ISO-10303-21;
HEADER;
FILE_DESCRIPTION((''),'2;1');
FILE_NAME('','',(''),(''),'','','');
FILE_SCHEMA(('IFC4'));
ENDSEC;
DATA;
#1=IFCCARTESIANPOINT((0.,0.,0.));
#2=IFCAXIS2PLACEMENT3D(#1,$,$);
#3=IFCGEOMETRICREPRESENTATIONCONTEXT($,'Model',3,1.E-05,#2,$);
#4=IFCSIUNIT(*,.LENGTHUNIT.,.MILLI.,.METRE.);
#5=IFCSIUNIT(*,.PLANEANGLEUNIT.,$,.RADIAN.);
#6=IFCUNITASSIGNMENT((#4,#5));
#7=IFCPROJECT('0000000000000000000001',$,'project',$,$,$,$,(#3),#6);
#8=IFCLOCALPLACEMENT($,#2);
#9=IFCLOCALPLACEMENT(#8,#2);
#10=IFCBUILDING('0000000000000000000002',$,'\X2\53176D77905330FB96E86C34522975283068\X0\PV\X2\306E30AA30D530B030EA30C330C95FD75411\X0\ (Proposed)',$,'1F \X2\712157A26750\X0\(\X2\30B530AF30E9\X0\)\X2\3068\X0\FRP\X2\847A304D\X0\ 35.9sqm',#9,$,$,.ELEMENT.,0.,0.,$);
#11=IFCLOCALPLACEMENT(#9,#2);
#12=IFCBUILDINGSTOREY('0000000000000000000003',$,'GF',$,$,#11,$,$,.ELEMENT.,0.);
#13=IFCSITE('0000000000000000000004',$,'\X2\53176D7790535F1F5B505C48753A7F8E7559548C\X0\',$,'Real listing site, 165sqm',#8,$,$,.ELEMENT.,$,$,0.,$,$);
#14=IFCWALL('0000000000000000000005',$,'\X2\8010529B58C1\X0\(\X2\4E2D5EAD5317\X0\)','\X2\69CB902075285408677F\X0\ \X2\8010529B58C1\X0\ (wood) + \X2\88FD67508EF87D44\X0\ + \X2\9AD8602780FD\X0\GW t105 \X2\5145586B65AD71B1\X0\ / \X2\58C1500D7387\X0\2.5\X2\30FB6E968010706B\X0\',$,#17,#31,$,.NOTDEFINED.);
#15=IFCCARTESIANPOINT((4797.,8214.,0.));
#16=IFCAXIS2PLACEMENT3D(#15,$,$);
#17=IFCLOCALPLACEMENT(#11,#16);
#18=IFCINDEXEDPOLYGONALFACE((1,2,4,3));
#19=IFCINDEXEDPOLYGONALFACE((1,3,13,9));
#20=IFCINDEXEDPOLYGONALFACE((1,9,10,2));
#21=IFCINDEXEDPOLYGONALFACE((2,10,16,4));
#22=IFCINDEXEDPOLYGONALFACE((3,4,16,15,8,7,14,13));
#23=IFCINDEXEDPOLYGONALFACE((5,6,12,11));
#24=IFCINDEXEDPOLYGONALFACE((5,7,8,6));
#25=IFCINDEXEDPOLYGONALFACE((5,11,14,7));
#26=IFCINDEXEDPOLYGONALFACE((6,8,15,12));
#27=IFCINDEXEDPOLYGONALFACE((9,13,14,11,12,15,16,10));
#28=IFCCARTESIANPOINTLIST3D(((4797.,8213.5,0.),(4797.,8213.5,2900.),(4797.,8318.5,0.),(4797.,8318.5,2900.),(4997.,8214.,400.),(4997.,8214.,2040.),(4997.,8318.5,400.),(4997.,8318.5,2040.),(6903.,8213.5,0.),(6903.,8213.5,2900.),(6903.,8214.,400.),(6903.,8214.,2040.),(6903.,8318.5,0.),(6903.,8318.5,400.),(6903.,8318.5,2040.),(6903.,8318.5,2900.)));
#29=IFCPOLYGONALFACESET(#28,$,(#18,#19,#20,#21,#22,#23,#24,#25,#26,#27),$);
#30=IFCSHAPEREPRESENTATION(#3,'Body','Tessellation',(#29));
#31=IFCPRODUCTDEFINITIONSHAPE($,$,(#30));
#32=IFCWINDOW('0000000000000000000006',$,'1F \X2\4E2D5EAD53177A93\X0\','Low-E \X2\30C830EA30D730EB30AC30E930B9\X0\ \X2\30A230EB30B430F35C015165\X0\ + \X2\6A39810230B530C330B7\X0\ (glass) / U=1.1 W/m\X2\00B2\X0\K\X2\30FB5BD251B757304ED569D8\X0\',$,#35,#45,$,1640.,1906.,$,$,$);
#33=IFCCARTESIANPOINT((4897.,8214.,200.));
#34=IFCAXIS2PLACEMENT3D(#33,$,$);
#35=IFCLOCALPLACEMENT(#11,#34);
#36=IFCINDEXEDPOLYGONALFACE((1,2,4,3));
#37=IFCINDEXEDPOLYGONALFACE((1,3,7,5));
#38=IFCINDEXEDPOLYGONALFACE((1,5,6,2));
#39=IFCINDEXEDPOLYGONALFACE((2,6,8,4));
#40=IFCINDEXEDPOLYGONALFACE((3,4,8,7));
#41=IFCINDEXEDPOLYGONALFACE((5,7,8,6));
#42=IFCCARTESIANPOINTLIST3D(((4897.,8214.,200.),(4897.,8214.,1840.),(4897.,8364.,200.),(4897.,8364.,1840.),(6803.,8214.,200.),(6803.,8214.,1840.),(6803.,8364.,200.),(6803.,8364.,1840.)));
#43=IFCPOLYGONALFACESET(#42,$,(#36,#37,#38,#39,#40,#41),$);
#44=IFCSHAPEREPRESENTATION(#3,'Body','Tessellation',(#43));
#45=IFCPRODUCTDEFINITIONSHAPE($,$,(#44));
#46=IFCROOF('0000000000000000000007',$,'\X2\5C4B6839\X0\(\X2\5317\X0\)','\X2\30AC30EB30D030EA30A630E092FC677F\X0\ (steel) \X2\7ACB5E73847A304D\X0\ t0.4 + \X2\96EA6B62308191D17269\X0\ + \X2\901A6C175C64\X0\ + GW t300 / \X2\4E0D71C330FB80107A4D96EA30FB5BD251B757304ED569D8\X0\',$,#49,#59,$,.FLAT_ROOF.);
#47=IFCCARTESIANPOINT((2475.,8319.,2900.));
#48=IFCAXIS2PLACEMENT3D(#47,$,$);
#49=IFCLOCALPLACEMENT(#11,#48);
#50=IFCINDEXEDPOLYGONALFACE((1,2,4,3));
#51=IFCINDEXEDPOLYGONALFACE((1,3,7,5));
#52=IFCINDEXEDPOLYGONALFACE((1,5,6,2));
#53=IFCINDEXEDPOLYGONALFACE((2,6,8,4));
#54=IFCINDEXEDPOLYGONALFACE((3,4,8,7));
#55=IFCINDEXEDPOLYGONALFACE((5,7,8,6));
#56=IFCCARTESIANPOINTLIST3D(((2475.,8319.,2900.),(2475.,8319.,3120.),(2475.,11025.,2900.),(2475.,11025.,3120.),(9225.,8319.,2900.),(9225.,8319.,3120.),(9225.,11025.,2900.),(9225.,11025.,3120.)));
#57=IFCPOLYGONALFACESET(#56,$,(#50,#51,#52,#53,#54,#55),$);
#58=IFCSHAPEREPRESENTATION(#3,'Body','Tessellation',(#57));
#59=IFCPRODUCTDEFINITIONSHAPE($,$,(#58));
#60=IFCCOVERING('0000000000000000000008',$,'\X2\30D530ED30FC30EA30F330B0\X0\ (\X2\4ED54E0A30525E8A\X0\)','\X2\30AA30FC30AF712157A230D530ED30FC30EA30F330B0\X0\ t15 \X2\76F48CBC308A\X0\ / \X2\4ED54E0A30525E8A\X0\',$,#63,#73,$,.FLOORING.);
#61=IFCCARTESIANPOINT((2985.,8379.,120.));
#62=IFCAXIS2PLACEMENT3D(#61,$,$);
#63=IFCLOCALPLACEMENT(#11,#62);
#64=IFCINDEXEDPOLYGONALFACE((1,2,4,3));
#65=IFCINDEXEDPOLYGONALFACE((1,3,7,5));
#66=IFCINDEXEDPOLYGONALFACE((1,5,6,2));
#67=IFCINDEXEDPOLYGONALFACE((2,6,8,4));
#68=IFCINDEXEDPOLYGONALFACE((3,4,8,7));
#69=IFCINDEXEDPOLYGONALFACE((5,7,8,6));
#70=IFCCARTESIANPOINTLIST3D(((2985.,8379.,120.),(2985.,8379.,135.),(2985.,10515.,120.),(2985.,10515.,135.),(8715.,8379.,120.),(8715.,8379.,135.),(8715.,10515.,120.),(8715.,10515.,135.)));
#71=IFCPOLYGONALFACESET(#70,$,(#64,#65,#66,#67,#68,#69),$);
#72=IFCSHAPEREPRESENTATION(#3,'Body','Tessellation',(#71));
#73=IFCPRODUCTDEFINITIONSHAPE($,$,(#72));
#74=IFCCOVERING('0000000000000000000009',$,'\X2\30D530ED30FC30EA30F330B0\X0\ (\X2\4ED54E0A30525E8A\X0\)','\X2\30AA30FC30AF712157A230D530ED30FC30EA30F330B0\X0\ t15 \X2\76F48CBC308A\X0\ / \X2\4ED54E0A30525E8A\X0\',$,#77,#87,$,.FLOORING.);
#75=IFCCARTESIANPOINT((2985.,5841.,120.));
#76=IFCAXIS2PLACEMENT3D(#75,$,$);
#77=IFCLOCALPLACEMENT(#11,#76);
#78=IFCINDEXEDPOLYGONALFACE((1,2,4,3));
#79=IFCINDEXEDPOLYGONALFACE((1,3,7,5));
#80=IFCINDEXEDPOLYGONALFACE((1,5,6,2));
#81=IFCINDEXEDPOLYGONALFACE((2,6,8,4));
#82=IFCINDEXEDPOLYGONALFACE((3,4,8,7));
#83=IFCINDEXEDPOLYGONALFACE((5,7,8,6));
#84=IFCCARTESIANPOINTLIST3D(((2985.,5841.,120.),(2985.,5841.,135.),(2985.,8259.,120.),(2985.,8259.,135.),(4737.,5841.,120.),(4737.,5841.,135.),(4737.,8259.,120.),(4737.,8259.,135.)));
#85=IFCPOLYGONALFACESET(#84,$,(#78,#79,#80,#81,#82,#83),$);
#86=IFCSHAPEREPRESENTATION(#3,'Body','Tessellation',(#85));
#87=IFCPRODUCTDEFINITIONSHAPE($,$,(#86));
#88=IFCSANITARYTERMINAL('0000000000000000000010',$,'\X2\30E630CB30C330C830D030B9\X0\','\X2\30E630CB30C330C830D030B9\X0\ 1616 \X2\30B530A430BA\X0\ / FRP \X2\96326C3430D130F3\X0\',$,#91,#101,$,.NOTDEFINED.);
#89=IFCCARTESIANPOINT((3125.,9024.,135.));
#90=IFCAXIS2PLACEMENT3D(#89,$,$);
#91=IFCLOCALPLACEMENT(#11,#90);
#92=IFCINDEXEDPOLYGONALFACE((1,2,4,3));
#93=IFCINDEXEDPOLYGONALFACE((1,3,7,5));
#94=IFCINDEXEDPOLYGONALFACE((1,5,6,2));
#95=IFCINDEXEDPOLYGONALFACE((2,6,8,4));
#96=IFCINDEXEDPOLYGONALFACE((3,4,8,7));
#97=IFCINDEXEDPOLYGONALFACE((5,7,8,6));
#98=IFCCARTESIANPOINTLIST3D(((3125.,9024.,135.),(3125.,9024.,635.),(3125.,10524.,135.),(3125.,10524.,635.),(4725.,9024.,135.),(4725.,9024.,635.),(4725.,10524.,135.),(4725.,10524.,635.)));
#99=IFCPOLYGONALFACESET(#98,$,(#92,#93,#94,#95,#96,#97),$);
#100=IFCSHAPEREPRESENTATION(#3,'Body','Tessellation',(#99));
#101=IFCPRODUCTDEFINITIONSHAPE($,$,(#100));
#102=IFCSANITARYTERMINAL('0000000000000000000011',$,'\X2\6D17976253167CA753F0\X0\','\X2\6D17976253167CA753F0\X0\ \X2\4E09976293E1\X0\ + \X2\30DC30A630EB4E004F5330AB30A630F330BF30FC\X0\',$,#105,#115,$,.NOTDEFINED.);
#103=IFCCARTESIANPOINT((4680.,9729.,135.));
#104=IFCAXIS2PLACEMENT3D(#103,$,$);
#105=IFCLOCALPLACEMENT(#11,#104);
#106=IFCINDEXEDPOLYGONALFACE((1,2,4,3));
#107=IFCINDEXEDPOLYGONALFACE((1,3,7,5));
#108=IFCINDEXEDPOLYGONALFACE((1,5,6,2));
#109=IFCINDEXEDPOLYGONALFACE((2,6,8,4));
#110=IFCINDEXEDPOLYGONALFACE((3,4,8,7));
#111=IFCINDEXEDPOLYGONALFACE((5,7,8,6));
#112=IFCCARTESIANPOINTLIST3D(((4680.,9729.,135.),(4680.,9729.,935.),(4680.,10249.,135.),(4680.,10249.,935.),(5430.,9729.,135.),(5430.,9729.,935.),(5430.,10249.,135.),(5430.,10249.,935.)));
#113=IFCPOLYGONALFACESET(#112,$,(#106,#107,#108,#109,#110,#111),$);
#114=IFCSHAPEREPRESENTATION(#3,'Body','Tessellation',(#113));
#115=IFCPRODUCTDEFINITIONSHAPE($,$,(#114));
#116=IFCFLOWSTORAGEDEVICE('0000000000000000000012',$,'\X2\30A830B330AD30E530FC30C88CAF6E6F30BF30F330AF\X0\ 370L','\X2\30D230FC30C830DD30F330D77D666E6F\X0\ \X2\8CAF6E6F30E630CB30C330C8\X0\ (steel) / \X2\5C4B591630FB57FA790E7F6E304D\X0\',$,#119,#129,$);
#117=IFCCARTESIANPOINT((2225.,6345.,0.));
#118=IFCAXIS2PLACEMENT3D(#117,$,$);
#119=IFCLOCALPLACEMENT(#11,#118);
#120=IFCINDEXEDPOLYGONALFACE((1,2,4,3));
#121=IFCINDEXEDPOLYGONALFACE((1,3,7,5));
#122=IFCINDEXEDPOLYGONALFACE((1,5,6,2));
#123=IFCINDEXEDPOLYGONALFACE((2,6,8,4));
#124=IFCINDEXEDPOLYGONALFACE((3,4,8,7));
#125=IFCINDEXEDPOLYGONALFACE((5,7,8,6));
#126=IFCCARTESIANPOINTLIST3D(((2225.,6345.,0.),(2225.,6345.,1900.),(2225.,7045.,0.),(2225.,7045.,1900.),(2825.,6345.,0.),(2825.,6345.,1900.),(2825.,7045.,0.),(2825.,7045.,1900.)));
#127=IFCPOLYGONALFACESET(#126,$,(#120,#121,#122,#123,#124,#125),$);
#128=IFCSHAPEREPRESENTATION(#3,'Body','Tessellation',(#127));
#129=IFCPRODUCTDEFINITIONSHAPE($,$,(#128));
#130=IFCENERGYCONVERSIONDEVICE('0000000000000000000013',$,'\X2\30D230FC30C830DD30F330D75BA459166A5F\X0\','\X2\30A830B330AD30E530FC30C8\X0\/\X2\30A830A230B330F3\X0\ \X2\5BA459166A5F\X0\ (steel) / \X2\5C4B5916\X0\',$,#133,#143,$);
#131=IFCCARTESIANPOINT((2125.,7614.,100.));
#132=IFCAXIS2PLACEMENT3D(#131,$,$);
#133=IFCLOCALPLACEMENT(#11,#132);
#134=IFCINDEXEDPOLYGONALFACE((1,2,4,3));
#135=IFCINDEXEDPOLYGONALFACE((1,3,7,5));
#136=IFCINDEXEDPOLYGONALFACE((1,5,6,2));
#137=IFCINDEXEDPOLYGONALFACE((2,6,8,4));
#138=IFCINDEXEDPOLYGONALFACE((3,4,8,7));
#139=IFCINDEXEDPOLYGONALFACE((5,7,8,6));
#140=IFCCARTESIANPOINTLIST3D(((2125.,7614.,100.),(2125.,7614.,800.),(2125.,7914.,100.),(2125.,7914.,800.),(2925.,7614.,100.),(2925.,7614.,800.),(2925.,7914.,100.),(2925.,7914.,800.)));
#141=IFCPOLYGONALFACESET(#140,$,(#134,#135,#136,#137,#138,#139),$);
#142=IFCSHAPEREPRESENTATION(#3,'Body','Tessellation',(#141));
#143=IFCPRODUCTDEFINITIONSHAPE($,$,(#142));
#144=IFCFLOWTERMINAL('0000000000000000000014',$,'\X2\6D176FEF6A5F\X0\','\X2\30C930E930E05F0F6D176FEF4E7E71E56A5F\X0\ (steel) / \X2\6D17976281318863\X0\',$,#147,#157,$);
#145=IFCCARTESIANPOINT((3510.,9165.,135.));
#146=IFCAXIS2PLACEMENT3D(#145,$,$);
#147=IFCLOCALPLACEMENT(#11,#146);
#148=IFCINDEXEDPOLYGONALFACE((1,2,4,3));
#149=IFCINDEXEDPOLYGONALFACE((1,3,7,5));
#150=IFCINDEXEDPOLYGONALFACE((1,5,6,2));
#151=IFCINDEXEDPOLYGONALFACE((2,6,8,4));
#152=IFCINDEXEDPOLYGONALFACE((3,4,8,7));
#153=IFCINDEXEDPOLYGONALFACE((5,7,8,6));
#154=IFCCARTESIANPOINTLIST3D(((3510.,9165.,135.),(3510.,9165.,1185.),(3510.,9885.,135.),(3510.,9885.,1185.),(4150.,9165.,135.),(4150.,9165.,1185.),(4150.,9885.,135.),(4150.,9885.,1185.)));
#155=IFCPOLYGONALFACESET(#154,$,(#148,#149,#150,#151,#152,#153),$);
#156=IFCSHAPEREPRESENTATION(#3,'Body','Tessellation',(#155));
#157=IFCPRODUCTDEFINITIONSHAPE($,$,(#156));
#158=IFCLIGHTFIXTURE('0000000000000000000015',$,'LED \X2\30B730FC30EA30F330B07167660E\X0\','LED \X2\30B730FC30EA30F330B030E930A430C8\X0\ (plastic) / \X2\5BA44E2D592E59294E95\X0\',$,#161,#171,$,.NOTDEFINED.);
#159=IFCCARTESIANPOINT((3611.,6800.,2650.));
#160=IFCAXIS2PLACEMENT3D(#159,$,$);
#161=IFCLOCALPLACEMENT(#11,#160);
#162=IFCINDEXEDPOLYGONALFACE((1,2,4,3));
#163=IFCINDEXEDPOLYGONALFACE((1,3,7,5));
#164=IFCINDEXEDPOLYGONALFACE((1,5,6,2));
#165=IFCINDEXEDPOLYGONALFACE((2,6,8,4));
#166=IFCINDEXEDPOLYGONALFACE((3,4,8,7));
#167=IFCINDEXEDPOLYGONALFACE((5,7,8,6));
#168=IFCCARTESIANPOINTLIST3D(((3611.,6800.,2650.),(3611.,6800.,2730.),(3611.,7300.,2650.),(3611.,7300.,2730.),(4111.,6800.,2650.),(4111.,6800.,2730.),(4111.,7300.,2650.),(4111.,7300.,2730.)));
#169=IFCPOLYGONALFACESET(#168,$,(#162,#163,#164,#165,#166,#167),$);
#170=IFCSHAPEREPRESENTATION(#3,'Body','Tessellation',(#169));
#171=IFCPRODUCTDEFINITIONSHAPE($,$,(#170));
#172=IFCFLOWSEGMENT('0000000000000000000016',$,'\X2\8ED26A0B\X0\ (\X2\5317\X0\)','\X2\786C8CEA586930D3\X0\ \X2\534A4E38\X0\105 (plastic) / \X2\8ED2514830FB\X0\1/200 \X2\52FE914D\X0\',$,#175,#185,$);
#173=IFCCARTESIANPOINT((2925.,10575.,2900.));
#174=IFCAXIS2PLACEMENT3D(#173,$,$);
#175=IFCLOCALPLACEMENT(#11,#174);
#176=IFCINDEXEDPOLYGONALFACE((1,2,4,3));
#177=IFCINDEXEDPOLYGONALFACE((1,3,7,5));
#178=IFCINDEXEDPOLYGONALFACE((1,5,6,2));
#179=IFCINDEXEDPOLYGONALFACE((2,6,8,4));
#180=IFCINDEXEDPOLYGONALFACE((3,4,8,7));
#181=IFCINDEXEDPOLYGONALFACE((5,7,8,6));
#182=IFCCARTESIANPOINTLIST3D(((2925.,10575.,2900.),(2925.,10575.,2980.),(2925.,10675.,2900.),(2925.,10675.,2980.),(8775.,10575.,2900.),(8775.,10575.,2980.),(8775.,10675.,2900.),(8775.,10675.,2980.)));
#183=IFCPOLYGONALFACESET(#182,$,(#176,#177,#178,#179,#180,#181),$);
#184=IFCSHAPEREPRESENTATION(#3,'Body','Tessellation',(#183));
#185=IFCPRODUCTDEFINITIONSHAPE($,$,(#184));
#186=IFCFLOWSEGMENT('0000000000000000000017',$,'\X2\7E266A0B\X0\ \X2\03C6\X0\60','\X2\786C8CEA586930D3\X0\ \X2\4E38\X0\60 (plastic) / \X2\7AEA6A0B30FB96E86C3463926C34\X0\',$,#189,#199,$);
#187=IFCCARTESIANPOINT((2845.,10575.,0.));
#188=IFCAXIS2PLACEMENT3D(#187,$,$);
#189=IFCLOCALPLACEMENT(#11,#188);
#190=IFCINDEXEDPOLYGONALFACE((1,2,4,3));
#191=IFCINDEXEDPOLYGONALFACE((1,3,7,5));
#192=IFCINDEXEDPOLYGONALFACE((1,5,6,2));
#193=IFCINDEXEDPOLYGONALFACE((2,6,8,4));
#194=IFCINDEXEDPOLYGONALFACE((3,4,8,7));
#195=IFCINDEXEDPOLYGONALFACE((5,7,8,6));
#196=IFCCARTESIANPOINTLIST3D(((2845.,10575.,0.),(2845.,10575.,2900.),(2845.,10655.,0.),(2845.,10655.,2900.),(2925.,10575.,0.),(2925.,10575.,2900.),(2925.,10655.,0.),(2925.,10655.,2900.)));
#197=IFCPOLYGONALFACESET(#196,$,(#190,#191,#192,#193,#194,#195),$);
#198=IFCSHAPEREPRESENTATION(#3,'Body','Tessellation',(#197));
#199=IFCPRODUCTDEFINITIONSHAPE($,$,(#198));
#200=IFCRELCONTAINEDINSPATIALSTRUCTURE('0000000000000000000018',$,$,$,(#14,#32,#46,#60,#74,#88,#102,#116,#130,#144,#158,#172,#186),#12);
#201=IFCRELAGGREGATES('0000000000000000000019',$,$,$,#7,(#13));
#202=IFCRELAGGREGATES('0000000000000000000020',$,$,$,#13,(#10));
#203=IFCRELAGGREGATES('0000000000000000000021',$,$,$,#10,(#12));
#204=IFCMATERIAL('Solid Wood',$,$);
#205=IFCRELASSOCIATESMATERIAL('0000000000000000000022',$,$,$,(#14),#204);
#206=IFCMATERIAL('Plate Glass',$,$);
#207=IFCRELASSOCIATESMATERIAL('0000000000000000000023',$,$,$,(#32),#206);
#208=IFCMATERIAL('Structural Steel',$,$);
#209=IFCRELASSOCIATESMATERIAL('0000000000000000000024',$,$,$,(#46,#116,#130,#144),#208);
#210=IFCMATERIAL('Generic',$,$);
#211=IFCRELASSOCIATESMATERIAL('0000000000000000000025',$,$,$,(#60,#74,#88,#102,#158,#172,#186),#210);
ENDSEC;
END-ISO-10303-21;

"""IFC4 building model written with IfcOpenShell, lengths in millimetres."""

from ifc_helpers import new_model, si_unit, frame, frame_2d, origin, place, context, project, spatial, rectangle, extrude, material, element, fill, save


model = new_model("IFC4")

# Units and contexts
model_context = context("Model", 3, precision=1e-05, world=origin())
ifc_project = project(units=[si_unit("LENGTHUNIT", "METRE", prefix="MILLI"), si_unit("PLANEANGLEUNIT", "RADIAN")], contexts=[model_context])

# Site, building, storey
site_placement = place(None, origin())
site = spatial("IfcSite", under=ifc_project, at=site_placement, Name="北海道弟子屈町美留和", ObjectType="Real listing site, 165sqm", CompositionType="ELEMENT", RefElevation=0.0)
building_placement = place(site_placement, origin())
building = spatial("IfcBuilding", under=site, at=building_placement, Name="北海道・雨水利用とPVのオフグリッド志向 (Proposed)", ObjectType="1F 無垢材(サクラ)とFRP葺き 35.9sqm", CompositionType="ELEMENT", ElevationOfRefHeight=0.0, ElevationOfTerrain=0.0)
storey_placement = place(building_placement, origin())
storey = spatial("IfcBuildingStorey", under=building, at=storey_placement, Name="GF", CompositionType="ELEMENT", Elevation=0.0)

# Shared definitions
ifc_material_1 = material(Name="Solid Wood")

# Shared definitions
ifc_material_2 = material(Name="Plate Glass")

# Wall, opening, window
wall_1_placement = place(storey_placement, frame((4797.0, 8214.0, 0.0)))
wall_1 = element("IfcWall", 1, at=wall_1_placement, inside=storey, material=ifc_material_1, Name="耐力壁(中庭北)", Description="構造用合板 耐力壁 (wood) + 製材軸組 + 高性能GW t105 充填断熱 / 壁倍率2.5・準耐火", PredefinedType="NOTDEFINED", context=model_context, shape_type="SweptSolid", body=[
    extrude(rectangle(XDim=2106.0, YDim=105.0, at=frame_2d((1053.0, 52.0))), frame((4797.0, 8214.0, 0.0)), (0.0, 0.0, 1.0), 2900.0),
])
opening_1_placement = place(storey_placement, frame((4897.0, 8214.0, 200.0)))
opening_1 = element("IfcOpeningElement", 2, at=opening_1_placement, cuts=wall_1, PredefinedType="NOTDEFINED", context=model_context, shape_type="SweptSolid", body=[
    extrude(rectangle(XDim=1906.0, YDim=150.0, at=frame_2d((953.0, 75.0))), frame((4897.0, 8214.0, 200.0)), (0.0, 0.0, 1.0), 1640.0),
])
window_1_placement = place(storey_placement, frame((4897.0, 8214.0, 200.0)))
window_1 = element("IfcWindow", 3, at=window_1_placement, inside=storey, material=ifc_material_2, Name="1F 中庭北窓", Description="Low-E トリプルガラス アルゴン封入 + 樹脂サッシ (glass) / U=1.1 W/m²K・寒冷地仕様", OverallHeight=1640.0, OverallWidth=1906.0, context=model_context, shape_type="SweptSolid", body=[
    extrude(rectangle(XDim=1906.0, YDim=150.0, at=frame_2d((953.0, 75.0))), frame((4897.0, 8214.0, 200.0)), (0.0, 0.0, 1.0), 1640.0),
])
fill(opening_1, window_1)

# Roof
ifc_material_3 = material(Name="Structural Steel")
roof_placement = place(storey_placement, frame((2475.0, 8319.0, 2900.0)))
element("IfcRoof", 4, at=roof_placement, inside=storey, material=ifc_material_3, Name="屋根(北)", Description="ガルバリウム鋼板 (steel) 立平葺き t0.4 + 雪止め金物 + 通気層 + GW t300 / 不燃・耐積雪・寒冷地仕様", PredefinedType="FLAT_ROOF", context=model_context, shape_type="SweptSolid", body=[
    extrude(rectangle(XDim=6750.0, YDim=2706.0, at=frame_2d((3375.0, 1353.0))), frame((2475.0, 8319.0, 2900.0)), (0.0, 0.0, 1.0), 220.0),
])

# Coverings
ifc_material_4 = material(Name="Generic")
covering_1_placement = place(storey_placement, frame((2985.0, 8379.0, 120.0)))
element("IfcCovering", 5, at=covering_1_placement, inside=storey, material=ifc_material_4, Name="フローリング (仕上げ床)", Description="オーク無垢フローリング t15 直貼り / 仕上げ床", PredefinedType="FLOORING", context=model_context, shape_type="SweptSolid", body=[
    extrude(rectangle(XDim=5730.0, YDim=2136.0, at=frame_2d((2865.0, 1068.0))), frame((2985.0, 8379.0, 120.0)), (0.0, 0.0, 1.0), 15.0),
])
covering_2_placement = place(storey_placement, frame((2985.0, 5841.0, 120.0)))
element("IfcCovering", 6, at=covering_2_placement, inside=storey, material=ifc_material_4, Name="フローリング (仕上げ床)", Description="オーク無垢フローリング t15 直貼り / 仕上げ床", PredefinedType="FLOORING", context=model_context, shape_type="SweptSolid", body=[
    extrude(rectangle(XDim=1752.0, YDim=2418.0, at=frame_2d((876.0, 1209.0))), frame((2985.0, 5841.0, 120.0)), (0.0, 0.0, 1.0), 15.0),
])

# Sanitary terminals
sanitary_terminal_1_placement = place(storey_placement, frame((3125.0, 9024.0, 135.0)))
element("IfcSanitaryTerminal", 7, at=sanitary_terminal_1_placement, inside=storey, material=ifc_material_4, Name="ユニットバス", Description="ユニットバス 1616 サイズ / FRP 防水パン", PredefinedType="NOTDEFINED", context=model_context, shape_type="SweptSolid", body=[
    extrude(rectangle(XDim=1600.0, YDim=1500.0, at=frame_2d((800.0, 750.0))), frame((3125.0, 9024.0, 135.0)), (0.0, 0.0, 1.0), 500.0),
])
sanitary_terminal_2_placement = place(storey_placement, frame((4680.0, 9729.0, 135.0)))
element("IfcSanitaryTerminal", 8, at=sanitary_terminal_2_placement, inside=storey, material=ifc_material_4, Name="洗面化粧台", Description="洗面化粧台 三面鏡 + ボウル一体カウンター", PredefinedType="NOTDEFINED", context=model_context, shape_type="SweptSolid", body=[
    extrude(rectangle(XDim=750.0, YDim=520.0, at=frame_2d((375.0, 260.0))), frame((4680.0, 9729.0, 135.0)), (0.0, 0.0, 1.0), 800.0),
])

# Flow storage device
flow_storage_device_placement = place(storey_placement, frame((2225.0, 6345.0, 0.0)))
element("IfcFlowStorageDevice", 9, at=flow_storage_device_placement, inside=storey, material=ifc_material_3, Name="エコキュート貯湯タンク 370L", Description="ヒートポンプ給湯 貯湯ユニット (steel) / 屋外・基礎置き", context=model_context, shape_type="SweptSolid", body=[
    extrude(rectangle(XDim=600.0, YDim=700.0, at=frame_2d((300.0, 350.0))), frame((2225.0, 6345.0, 0.0)), (0.0, 0.0, 1.0), 1900.0),
])

# Energy conversion device
energy_conversion_device_placement = place(storey_placement, frame((2125.0, 7614.0, 100.0)))
element("IfcEnergyConversionDevice", 10, at=energy_conversion_device_placement, inside=storey, material=ifc_material_3, Name="ヒートポンプ室外機", Description="エコキュート/エアコン 室外機 (steel) / 屋外", context=model_context, shape_type="SweptSolid", body=[
    extrude(rectangle(XDim=800.0, YDim=300.0, at=frame_2d((400.0, 150.0))), frame((2125.0, 7614.0, 100.0)), (0.0, 0.0, 1.0), 700.0),
])

# Flow terminal
flow_terminal_placement = place(storey_placement, frame((3510.0, 9165.0, 135.0)))
element("IfcFlowTerminal", 11, at=flow_terminal_placement, inside=storey, material=ifc_material_3, Name="洗濯機", Description="ドラム式洗濯乾燥機 (steel) / 洗面脱衣", context=model_context, shape_type="SweptSolid", body=[
    extrude(rectangle(XDim=640.0, YDim=720.0, at=frame_2d((320.0, 360.0))), frame((3510.0, 9165.0, 135.0)), (0.0, 0.0, 1.0), 1050.0),
])

# Light fixture
light_fixture_placement = place(storey_placement, frame((3611.0, 6800.0, 2650.0)))
element("IfcLightFixture", 12, at=light_fixture_placement, inside=storey, material=ifc_material_4, Name="LED シーリング照明", Description="LED シーリングライト (plastic) / 室中央天井", PredefinedType="NOTDEFINED", context=model_context, shape_type="SweptSolid", body=[
    extrude(rectangle(XDim=500.0, YDim=500.0, at=frame_2d((250.0, 250.0))), frame((3611.0, 6800.0, 2650.0)), (0.0, 0.0, 1.0), 80.0),
])

# Flow segments
flow_segment_1_placement = place(storey_placement, frame((2925.0, 10575.0, 2900.0)))
element("IfcFlowSegment", 13, at=flow_segment_1_placement, inside=storey, material=ifc_material_4, Name="軒樋 (北)", Description="硬質塩ビ 半丸105 (plastic) / 軒先・1/200 勾配", context=model_context, shape_type="SweptSolid", body=[
    extrude(rectangle(XDim=5850.0, YDim=100.0, at=frame_2d((2925.0, 50.0))), frame((2925.0, 10575.0, 2900.0)), (0.0, 0.0, 1.0), 80.0),
])
flow_segment_2_placement = place(storey_placement, frame((2845.0, 10575.0, 0.0)))
element("IfcFlowSegment", 14, at=flow_segment_2_placement, inside=storey, material=ifc_material_4, Name="縦樋 φ60", Description="硬質塩ビ 丸60 (plastic) / 竪樋・雨水排水", context=model_context, shape_type="SweptSolid", body=[
    extrude(rectangle(XDim=80.0, YDim=80.0, at=frame_2d((40.0, 40.0))), frame((2845.0, 10575.0, 0.0)), (0.0, 0.0, 1.0), 2900.0),
])

save(model, "model.ifc")
